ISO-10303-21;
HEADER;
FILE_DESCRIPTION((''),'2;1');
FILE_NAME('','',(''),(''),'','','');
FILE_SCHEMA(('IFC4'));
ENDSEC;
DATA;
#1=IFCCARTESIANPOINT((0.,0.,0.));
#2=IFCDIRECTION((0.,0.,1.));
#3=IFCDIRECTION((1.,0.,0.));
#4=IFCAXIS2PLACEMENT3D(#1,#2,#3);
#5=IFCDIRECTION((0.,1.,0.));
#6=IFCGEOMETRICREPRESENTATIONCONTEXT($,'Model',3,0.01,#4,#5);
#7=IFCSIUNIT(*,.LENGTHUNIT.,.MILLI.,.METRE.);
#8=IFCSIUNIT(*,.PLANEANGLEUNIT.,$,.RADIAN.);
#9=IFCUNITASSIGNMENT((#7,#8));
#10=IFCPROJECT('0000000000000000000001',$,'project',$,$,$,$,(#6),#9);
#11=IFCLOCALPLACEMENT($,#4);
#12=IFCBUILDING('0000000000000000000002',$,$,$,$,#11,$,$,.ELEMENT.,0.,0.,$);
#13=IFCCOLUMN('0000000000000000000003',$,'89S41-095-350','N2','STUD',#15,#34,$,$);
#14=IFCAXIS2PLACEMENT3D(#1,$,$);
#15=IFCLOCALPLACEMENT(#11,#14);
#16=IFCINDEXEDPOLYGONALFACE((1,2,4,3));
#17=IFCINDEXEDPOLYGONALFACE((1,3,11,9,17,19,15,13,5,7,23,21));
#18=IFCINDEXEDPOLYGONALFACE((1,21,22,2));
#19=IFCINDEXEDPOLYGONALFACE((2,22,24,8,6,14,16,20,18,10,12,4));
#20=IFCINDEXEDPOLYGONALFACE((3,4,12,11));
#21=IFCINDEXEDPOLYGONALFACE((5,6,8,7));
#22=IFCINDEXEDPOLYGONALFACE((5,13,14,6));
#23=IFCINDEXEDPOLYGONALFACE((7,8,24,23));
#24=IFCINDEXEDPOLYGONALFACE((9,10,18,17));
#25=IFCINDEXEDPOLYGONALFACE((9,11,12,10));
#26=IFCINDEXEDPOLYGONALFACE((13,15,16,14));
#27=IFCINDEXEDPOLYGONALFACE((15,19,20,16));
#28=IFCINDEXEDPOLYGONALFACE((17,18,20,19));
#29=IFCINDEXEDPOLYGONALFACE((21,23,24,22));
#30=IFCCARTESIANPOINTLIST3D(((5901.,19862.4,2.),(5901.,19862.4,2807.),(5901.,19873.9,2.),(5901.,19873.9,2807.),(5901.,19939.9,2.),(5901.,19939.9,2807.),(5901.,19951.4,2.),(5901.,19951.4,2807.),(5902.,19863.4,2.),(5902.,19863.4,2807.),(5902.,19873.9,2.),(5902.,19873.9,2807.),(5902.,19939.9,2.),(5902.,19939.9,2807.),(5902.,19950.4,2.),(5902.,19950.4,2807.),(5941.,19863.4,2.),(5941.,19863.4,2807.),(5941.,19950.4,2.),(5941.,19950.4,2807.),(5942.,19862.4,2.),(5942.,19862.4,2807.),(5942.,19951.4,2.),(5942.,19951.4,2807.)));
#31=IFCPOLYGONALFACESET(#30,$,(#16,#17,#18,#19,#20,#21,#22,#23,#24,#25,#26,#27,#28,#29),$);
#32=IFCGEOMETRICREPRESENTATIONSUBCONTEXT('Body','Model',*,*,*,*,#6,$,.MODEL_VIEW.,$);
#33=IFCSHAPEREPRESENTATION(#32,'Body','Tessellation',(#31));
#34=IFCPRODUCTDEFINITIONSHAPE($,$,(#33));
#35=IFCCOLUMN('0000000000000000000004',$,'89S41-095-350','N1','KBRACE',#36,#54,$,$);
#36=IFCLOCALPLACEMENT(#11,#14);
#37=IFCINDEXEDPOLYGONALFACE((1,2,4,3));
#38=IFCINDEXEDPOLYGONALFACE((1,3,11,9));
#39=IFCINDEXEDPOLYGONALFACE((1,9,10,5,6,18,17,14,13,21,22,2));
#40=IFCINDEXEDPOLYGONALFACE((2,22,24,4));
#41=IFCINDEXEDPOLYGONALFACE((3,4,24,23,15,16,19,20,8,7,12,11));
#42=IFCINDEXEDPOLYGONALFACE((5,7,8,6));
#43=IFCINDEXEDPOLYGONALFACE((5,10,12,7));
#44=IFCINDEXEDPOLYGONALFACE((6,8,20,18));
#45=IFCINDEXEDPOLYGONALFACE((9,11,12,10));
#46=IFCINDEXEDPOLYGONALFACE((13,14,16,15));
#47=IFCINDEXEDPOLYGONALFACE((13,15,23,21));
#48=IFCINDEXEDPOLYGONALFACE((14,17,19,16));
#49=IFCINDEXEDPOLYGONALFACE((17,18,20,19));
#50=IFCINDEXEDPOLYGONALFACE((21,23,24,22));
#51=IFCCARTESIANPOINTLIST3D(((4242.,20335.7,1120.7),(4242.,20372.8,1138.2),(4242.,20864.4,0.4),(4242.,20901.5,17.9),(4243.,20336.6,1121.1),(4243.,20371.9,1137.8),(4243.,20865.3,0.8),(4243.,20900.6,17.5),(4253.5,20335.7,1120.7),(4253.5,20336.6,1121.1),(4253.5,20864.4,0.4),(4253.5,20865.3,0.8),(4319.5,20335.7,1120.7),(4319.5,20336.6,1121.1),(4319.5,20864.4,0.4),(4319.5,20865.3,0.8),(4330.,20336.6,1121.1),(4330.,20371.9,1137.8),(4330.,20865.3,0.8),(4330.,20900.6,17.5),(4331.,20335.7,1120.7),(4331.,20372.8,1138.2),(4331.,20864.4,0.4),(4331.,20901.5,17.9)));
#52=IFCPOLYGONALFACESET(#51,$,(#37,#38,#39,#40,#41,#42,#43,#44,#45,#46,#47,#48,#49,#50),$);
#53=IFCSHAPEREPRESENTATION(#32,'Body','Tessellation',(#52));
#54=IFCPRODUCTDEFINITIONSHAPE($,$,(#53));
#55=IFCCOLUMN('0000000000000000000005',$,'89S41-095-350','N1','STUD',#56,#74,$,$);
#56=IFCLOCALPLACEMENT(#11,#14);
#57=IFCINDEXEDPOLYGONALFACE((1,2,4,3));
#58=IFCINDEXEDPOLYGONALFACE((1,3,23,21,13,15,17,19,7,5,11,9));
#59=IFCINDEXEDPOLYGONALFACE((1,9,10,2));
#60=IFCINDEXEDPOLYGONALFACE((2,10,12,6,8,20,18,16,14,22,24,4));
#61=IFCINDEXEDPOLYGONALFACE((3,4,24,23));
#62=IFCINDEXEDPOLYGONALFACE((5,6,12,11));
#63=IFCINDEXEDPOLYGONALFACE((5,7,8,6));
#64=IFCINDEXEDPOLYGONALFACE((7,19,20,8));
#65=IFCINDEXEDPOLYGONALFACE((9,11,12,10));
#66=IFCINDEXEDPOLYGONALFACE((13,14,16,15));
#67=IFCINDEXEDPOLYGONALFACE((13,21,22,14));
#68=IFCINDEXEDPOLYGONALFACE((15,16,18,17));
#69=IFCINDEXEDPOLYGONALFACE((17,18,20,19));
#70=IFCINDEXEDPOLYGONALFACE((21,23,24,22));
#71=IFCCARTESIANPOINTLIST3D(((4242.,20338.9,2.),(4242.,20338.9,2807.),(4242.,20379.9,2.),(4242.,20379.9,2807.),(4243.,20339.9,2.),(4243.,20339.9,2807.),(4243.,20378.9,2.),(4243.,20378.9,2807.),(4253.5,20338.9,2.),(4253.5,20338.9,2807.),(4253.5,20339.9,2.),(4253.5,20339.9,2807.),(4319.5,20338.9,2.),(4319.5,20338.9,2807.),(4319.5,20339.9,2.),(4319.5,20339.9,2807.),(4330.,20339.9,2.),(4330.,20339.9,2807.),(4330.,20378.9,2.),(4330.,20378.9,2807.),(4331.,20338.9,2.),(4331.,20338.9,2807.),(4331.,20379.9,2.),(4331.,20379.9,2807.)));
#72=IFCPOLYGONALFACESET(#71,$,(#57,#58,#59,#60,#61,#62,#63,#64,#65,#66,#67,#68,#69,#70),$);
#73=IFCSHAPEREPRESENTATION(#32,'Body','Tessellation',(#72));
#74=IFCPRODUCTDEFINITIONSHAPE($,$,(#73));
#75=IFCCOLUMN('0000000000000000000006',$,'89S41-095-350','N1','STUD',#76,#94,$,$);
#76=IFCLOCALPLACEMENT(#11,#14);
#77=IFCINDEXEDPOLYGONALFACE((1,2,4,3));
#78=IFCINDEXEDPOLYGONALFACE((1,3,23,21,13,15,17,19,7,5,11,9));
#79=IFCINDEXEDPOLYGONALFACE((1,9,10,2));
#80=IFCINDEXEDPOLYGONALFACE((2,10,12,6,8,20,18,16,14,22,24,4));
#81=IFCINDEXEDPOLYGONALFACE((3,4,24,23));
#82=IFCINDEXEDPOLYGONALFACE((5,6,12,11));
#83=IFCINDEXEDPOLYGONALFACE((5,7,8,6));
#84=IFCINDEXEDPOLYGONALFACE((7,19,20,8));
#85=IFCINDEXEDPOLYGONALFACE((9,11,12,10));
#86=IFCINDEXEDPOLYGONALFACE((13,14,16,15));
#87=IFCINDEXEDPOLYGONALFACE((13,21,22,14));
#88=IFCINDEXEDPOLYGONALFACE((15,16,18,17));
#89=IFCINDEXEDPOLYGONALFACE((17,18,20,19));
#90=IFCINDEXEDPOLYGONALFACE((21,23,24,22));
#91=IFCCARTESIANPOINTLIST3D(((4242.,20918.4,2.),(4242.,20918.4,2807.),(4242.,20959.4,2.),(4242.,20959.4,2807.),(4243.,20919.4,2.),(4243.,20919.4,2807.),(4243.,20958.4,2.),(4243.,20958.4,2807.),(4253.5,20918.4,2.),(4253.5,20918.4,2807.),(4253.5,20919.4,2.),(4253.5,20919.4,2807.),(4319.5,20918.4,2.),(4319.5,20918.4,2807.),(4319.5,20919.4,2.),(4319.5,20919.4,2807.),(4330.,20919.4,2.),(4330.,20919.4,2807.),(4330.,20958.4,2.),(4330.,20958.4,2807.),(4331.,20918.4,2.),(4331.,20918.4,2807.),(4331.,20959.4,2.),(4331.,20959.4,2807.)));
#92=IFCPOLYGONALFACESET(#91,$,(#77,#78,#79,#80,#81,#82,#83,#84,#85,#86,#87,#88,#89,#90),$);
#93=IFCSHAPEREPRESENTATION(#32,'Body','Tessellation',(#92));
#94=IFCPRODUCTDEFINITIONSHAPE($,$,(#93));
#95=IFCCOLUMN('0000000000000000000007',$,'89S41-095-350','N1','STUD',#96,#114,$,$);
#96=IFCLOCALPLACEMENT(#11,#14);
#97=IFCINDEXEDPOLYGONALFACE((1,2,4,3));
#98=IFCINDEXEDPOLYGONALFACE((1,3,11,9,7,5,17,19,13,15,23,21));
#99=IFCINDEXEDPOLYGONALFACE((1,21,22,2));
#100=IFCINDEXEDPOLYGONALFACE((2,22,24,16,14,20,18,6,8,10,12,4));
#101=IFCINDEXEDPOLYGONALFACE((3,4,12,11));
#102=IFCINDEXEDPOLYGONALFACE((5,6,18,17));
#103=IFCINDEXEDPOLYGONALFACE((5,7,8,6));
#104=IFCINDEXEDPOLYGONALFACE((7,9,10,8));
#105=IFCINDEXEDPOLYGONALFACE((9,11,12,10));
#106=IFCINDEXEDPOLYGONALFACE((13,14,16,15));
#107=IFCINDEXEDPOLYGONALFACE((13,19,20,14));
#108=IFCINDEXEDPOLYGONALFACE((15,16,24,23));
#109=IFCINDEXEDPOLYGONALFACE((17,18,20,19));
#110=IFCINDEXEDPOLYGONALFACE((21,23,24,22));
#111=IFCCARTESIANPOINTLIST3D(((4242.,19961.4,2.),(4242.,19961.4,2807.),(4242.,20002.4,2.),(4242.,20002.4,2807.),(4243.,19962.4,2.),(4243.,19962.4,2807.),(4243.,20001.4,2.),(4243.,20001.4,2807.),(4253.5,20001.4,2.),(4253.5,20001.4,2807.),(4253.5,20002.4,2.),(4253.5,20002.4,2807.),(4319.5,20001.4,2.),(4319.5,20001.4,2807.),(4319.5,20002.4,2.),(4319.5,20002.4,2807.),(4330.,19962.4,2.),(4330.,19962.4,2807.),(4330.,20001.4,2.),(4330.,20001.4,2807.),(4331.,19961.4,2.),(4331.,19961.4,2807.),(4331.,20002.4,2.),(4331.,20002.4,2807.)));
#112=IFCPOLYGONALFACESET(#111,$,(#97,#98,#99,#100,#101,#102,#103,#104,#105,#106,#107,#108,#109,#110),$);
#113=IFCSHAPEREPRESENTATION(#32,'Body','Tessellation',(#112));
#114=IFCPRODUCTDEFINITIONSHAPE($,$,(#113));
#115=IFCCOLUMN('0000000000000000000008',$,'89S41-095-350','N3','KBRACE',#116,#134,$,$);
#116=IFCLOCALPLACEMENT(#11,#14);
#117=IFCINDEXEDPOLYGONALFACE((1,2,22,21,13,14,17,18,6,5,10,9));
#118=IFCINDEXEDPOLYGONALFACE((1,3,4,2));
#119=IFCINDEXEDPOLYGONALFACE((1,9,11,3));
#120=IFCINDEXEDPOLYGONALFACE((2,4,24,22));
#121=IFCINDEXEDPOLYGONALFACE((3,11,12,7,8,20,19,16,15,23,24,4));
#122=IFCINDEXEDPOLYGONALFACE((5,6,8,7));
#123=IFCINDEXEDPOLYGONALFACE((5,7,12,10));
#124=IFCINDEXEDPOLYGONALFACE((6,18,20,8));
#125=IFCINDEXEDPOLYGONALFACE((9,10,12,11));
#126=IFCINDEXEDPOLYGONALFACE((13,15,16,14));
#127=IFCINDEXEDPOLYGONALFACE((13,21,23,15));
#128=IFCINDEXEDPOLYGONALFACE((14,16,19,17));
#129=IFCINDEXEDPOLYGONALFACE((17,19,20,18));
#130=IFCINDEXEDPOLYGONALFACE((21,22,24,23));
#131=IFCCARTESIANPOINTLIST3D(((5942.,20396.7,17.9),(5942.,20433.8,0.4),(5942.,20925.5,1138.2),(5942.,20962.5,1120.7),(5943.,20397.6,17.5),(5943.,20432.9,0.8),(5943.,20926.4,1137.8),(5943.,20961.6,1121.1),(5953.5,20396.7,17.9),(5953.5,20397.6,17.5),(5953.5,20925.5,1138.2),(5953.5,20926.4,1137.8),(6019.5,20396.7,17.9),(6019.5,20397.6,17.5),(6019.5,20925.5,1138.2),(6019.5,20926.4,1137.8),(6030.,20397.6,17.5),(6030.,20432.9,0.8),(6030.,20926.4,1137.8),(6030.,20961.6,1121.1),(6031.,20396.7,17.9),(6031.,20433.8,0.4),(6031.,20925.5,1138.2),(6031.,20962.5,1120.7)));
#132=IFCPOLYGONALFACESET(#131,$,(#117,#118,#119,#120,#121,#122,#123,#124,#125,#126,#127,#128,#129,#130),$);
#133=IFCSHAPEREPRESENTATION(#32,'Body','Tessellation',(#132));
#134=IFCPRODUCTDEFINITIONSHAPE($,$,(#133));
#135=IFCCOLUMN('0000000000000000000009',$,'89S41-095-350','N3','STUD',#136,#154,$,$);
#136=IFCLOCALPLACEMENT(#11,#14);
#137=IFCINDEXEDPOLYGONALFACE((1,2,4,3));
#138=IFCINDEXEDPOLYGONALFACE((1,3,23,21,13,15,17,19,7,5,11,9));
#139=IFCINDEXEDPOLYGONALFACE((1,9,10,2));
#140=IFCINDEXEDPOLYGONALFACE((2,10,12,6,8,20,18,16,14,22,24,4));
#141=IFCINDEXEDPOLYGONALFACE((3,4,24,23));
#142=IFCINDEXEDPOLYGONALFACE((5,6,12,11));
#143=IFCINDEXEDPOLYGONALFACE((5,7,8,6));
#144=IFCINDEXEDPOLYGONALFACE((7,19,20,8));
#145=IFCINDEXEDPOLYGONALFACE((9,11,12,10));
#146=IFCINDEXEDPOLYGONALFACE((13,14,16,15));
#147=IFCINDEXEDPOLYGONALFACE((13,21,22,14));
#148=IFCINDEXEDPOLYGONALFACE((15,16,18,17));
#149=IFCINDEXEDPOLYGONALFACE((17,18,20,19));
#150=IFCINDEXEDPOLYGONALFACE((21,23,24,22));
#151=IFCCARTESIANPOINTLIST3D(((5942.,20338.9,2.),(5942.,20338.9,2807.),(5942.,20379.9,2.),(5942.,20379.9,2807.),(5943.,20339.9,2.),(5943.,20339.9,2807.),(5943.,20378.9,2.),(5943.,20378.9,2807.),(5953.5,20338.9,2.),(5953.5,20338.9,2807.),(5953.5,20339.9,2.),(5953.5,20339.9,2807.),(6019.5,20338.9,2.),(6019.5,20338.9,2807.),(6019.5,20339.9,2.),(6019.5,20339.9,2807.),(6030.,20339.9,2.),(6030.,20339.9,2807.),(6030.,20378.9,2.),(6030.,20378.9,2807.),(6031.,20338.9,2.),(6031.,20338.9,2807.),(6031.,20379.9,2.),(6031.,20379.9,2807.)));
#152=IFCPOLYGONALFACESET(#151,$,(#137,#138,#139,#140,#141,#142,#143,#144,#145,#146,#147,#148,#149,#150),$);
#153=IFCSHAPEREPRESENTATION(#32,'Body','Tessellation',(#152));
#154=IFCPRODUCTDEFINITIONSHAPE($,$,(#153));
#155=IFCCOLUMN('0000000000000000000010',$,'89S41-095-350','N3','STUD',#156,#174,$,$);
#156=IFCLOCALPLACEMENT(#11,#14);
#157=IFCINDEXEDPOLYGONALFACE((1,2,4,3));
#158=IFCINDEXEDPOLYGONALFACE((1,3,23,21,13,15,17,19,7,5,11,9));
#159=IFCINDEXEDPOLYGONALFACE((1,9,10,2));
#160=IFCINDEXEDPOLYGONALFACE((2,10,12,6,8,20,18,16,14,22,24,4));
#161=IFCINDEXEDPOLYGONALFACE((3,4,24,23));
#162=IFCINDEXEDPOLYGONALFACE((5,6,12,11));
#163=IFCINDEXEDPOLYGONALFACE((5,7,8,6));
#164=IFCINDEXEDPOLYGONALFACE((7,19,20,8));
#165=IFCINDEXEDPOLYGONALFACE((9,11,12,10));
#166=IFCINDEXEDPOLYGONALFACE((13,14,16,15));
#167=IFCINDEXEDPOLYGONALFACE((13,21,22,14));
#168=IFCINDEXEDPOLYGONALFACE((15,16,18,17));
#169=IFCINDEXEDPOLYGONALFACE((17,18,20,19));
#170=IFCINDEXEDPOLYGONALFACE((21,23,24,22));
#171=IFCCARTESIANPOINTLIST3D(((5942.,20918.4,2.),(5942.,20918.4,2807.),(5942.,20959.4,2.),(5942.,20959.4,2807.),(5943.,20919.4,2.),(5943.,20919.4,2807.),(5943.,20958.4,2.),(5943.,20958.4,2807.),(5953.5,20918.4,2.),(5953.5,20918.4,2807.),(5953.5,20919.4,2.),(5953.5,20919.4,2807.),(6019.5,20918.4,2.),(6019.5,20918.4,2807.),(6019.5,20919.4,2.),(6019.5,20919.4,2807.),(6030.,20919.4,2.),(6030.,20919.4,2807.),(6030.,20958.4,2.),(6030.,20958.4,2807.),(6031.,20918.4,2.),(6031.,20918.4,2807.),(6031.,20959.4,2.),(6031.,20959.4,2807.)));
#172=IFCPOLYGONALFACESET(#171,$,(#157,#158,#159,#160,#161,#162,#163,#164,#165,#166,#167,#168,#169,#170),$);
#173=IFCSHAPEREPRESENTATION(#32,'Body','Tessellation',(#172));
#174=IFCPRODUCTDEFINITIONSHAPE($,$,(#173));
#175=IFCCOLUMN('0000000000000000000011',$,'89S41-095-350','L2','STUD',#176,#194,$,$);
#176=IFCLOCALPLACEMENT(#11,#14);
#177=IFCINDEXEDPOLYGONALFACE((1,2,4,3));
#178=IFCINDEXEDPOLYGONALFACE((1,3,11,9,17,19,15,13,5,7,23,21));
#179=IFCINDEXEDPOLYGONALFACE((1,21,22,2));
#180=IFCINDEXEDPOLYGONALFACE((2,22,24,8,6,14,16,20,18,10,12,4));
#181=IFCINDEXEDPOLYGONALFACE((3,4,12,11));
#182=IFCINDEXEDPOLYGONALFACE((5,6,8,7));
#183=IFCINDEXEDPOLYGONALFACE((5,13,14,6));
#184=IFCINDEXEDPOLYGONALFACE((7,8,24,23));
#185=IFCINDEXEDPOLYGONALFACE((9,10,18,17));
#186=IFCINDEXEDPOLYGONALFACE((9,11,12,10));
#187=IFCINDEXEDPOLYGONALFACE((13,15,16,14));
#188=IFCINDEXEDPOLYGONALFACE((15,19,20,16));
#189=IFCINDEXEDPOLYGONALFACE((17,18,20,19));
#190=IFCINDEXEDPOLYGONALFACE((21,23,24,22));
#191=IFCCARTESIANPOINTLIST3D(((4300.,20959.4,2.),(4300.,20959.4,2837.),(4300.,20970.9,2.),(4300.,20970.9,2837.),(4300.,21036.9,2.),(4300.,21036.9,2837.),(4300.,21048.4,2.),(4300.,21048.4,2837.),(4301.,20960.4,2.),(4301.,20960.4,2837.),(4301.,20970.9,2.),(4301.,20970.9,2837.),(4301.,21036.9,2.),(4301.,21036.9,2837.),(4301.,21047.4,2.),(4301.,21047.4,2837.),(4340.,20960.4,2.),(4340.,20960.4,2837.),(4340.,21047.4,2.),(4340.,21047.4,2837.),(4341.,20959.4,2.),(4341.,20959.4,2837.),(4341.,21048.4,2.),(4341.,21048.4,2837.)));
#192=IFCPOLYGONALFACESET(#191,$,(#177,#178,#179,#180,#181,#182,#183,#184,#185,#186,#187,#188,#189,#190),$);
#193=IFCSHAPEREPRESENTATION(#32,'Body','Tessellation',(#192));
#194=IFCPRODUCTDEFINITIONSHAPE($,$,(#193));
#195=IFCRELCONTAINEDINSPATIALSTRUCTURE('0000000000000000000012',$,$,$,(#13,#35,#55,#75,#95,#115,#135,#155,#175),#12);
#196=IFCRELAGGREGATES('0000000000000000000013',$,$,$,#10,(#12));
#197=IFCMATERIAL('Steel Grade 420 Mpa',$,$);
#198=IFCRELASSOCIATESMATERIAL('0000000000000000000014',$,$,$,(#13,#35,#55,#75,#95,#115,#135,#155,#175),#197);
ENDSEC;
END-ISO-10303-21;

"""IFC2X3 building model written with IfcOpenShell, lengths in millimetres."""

from ifc_helpers import new_model, si_unit, direction, frame, origin, origin_with_axes, origin_2d_with_axis, place, context, subcontext, project, spatial, c_section, extrude, source, transform, mapped, material, element, save


model = new_model("IFC2X3")

# Units and contexts
model_context = context("Model", 3, precision=0.01, world=origin_with_axes(), true_north=direction((0.0, 1.0, 0.0)))
body_context = subcontext(model_context, "Body", "Model", "MODEL_VIEW")
ifc_project = project(units=[si_unit("LENGTHUNIT", "METRE", prefix="MILLI"), si_unit("PLANEANGLEUNIT", "RADIAN")], contexts=[model_context])

# Building
building_placement = place(None, origin_with_axes())
building = spatial("IfcBuilding", under=ifc_project, at=building_placement, CompositionType="ELEMENT", ElevationOfRefHeight=0.0, ElevationOfTerrain=0.0)

# Columns
ifc_material = material(Name="Steel Grade 420 Mpa")
shared_shape_1 = source(origin(), body_context, "Body", "SweptSolid", [
    extrude(c_section(Depth=89.0, Width=41.0, WallThickness=1.0, Girth=11.5, at=origin_2d_with_axis()), origin_with_axes(), (0.0, 0.0, 1.0), 2805.0),
])
column_1_placement = place(None, frame((5921.5, 19906.9, 2.0), z_axis=(0.0, 0.0, 1.0), x_axis=(-1.0, 0.0, 0.0)))
element("IfcColumn", 1, at=column_1_placement, inside=building, material=ifc_material, Name="89S41-095-350", Description="N2", ObjectType="STUD", context=body_context, shape_type="MappedRepresentation", body=[
    mapped(shared_shape_1, transform((0.0, 0.0, 0.0), scale=1.0)),
])
shared_shape_2 = source(origin(), body_context, "Body", "SweptSolid", [
    extrude(c_section(Depth=89.0, Width=41.0, WallThickness=1.0, Girth=11.5, at=origin_2d_with_axis()), origin_with_axes(), (0.0, 0.0, 1.0), 1238.8),
])
column_2_placement = place(None, frame((4286.5, 20883.0, 9.1), z_axis=(0.0, -0.426791, 0.90435), x_axis=(0.0, -0.90435, -0.426791)))
element("IfcColumn", 2, at=column_2_placement, inside=building, material=ifc_material, Name="89S41-095-350", Description="N1", ObjectType="KBRACE", context=body_context, shape_type="MappedRepresentation", body=[
    mapped(shared_shape_2, transform((0.0, 0.0, 0.0), scale=1.0)),
])
shared_shape_3 = source(origin(), body_context, "Body", "SweptSolid", [
    extrude(c_section(Depth=89.0, Width=41.0, WallThickness=1.0, Girth=11.5, at=origin_2d_with_axis()), origin_with_axes(), (0.0, 0.0, 1.0), 2805.0),
])
column_3_placement = place(None, frame((4286.5, 20359.4, 2.0), z_axis=(0.0, 0.0, 1.0), x_axis=(0.0, -1.0, 0.0)))
element("IfcColumn", 3, at=column_3_placement, inside=building, material=ifc_material, Name="89S41-095-350", Description="N1", ObjectType="STUD", context=body_context, shape_type="MappedRepresentation", body=[
    mapped(shared_shape_3, transform((0.0, 0.0, 0.0), scale=1.0)),
])
shared_shape_4 = source(origin(), body_context, "Body", "SweptSolid", [
    extrude(c_section(Depth=89.0, Width=41.0, WallThickness=1.0, Girth=11.5, at=origin_2d_with_axis()), origin_with_axes(), (0.0, 0.0, 1.0), 2805.0),
])
column_4_placement = place(None, frame((4286.5, 20938.9, 2.0), z_axis=(0.0, 0.0, 1.0), x_axis=(0.0, -1.0, 0.0)))
element("IfcColumn", 4, at=column_4_placement, inside=building, material=ifc_material, Name="89S41-095-350", Description="N1", ObjectType="STUD", context=body_context, shape_type="MappedRepresentation", body=[
    mapped(shared_shape_4, transform((0.0, 0.0, 0.0), scale=1.0)),
])
shared_shape_5 = source(origin(), body_context, "Body", "SweptSolid", [
    extrude(c_section(Depth=89.0, Width=41.0, WallThickness=1.0, Girth=11.5, at=origin_2d_with_axis()), origin_with_axes(), (0.0, 0.0, 1.0), 2805.0),
])
column_5_placement = place(None, frame((4286.5, 19981.9, 2.0), z_axis=(0.0, 0.0, 1.0), x_axis=(0.0, 1.0, 0.0)))
element("IfcColumn", 5, at=column_5_placement, inside=building, material=ifc_material, Name="89S41-095-350", Description="N1", ObjectType="STUD", context=body_context, shape_type="MappedRepresentation", body=[
    mapped(shared_shape_5, transform((0.0, 0.0, 0.0), scale=1.0)),
])
shared_shape_6 = source(origin(), body_context, "Body", "SweptSolid", [
    extrude(c_section(Depth=89.0, Width=41.0, WallThickness=1.0, Girth=11.5, at=origin_2d_with_axis()), origin_with_axes(), (0.0, 0.0, 1.0), 1238.8),
])
column_6_placement = place(None, frame((5986.5, 20415.3, 9.1), z_axis=(0.0, 0.426791, 0.90435), x_axis=(0.0, -0.90435, 0.426791)))
element("IfcColumn", 6, at=column_6_placement, inside=building, material=ifc_material, Name="89S41-095-350", Description="N3", ObjectType="KBRACE", context=body_context, shape_type="MappedRepresentation", body=[
    mapped(shared_shape_6, transform((0.0, 0.0, 0.0), scale=1.0)),
])
shared_shape_7 = source(origin(), body_context, "Body", "SweptSolid", [
    extrude(c_section(Depth=89.0, Width=41.0, WallThickness=1.0, Girth=11.5, at=origin_2d_with_axis()), origin_with_axes(), (0.0, 0.0, 1.0), 2805.0),
])
column_7_placement = place(None, frame((5986.5, 20359.4, 2.0), z_axis=(0.0, 0.0, 1.0), x_axis=(0.0, -1.0, 0.0)))
element("IfcColumn", 7, at=column_7_placement, inside=building, material=ifc_material, Name="89S41-095-350", Description="N3", ObjectType="STUD", context=body_context, shape_type="MappedRepresentation", body=[
    mapped(shared_shape_7, transform((0.0, 0.0, 0.0), scale=1.0)),
])
shared_shape_8 = source(origin(), body_context, "Body", "SweptSolid", [
    extrude(c_section(Depth=89.0, Width=41.0, WallThickness=1.0, Girth=11.5, at=origin_2d_with_axis()), origin_with_axes(), (0.0, 0.0, 1.0), 2805.0),
])
column_8_placement = place(None, frame((5986.5, 20938.9, 2.0), z_axis=(0.0, 0.0, 1.0), x_axis=(0.0, -1.0, 0.0)))
element("IfcColumn", 8, at=column_8_placement, inside=building, material=ifc_material, Name="89S41-095-350", Description="N3", ObjectType="STUD", context=body_context, shape_type="MappedRepresentation", body=[
    mapped(shared_shape_8, transform((0.0, 0.0, 0.0), scale=1.0)),
])
shared_shape_9 = source(origin(), body_context, "Body", "SweptSolid", [
    extrude(c_section(Depth=89.0, Width=41.0, WallThickness=1.0, Girth=11.5, at=origin_2d_with_axis()), origin_with_axes(), (0.0, 0.0, 1.0), 2835.0),
])
column_9_placement = place(None, frame((4320.5, 21003.9, 2.0), z_axis=(0.0, 0.0, 1.0), x_axis=(-1.0, 0.0, 0.0)))
element("IfcColumn", 9, at=column_9_placement, inside=building, material=ifc_material, Name="89S41-095-350", Description="L2", ObjectType="STUD", context=body_context, shape_type="MappedRepresentation", body=[
    mapped(shared_shape_9, transform((0.0, 0.0, 0.0), scale=1.0)),
])

save(model, "model.ifc")
